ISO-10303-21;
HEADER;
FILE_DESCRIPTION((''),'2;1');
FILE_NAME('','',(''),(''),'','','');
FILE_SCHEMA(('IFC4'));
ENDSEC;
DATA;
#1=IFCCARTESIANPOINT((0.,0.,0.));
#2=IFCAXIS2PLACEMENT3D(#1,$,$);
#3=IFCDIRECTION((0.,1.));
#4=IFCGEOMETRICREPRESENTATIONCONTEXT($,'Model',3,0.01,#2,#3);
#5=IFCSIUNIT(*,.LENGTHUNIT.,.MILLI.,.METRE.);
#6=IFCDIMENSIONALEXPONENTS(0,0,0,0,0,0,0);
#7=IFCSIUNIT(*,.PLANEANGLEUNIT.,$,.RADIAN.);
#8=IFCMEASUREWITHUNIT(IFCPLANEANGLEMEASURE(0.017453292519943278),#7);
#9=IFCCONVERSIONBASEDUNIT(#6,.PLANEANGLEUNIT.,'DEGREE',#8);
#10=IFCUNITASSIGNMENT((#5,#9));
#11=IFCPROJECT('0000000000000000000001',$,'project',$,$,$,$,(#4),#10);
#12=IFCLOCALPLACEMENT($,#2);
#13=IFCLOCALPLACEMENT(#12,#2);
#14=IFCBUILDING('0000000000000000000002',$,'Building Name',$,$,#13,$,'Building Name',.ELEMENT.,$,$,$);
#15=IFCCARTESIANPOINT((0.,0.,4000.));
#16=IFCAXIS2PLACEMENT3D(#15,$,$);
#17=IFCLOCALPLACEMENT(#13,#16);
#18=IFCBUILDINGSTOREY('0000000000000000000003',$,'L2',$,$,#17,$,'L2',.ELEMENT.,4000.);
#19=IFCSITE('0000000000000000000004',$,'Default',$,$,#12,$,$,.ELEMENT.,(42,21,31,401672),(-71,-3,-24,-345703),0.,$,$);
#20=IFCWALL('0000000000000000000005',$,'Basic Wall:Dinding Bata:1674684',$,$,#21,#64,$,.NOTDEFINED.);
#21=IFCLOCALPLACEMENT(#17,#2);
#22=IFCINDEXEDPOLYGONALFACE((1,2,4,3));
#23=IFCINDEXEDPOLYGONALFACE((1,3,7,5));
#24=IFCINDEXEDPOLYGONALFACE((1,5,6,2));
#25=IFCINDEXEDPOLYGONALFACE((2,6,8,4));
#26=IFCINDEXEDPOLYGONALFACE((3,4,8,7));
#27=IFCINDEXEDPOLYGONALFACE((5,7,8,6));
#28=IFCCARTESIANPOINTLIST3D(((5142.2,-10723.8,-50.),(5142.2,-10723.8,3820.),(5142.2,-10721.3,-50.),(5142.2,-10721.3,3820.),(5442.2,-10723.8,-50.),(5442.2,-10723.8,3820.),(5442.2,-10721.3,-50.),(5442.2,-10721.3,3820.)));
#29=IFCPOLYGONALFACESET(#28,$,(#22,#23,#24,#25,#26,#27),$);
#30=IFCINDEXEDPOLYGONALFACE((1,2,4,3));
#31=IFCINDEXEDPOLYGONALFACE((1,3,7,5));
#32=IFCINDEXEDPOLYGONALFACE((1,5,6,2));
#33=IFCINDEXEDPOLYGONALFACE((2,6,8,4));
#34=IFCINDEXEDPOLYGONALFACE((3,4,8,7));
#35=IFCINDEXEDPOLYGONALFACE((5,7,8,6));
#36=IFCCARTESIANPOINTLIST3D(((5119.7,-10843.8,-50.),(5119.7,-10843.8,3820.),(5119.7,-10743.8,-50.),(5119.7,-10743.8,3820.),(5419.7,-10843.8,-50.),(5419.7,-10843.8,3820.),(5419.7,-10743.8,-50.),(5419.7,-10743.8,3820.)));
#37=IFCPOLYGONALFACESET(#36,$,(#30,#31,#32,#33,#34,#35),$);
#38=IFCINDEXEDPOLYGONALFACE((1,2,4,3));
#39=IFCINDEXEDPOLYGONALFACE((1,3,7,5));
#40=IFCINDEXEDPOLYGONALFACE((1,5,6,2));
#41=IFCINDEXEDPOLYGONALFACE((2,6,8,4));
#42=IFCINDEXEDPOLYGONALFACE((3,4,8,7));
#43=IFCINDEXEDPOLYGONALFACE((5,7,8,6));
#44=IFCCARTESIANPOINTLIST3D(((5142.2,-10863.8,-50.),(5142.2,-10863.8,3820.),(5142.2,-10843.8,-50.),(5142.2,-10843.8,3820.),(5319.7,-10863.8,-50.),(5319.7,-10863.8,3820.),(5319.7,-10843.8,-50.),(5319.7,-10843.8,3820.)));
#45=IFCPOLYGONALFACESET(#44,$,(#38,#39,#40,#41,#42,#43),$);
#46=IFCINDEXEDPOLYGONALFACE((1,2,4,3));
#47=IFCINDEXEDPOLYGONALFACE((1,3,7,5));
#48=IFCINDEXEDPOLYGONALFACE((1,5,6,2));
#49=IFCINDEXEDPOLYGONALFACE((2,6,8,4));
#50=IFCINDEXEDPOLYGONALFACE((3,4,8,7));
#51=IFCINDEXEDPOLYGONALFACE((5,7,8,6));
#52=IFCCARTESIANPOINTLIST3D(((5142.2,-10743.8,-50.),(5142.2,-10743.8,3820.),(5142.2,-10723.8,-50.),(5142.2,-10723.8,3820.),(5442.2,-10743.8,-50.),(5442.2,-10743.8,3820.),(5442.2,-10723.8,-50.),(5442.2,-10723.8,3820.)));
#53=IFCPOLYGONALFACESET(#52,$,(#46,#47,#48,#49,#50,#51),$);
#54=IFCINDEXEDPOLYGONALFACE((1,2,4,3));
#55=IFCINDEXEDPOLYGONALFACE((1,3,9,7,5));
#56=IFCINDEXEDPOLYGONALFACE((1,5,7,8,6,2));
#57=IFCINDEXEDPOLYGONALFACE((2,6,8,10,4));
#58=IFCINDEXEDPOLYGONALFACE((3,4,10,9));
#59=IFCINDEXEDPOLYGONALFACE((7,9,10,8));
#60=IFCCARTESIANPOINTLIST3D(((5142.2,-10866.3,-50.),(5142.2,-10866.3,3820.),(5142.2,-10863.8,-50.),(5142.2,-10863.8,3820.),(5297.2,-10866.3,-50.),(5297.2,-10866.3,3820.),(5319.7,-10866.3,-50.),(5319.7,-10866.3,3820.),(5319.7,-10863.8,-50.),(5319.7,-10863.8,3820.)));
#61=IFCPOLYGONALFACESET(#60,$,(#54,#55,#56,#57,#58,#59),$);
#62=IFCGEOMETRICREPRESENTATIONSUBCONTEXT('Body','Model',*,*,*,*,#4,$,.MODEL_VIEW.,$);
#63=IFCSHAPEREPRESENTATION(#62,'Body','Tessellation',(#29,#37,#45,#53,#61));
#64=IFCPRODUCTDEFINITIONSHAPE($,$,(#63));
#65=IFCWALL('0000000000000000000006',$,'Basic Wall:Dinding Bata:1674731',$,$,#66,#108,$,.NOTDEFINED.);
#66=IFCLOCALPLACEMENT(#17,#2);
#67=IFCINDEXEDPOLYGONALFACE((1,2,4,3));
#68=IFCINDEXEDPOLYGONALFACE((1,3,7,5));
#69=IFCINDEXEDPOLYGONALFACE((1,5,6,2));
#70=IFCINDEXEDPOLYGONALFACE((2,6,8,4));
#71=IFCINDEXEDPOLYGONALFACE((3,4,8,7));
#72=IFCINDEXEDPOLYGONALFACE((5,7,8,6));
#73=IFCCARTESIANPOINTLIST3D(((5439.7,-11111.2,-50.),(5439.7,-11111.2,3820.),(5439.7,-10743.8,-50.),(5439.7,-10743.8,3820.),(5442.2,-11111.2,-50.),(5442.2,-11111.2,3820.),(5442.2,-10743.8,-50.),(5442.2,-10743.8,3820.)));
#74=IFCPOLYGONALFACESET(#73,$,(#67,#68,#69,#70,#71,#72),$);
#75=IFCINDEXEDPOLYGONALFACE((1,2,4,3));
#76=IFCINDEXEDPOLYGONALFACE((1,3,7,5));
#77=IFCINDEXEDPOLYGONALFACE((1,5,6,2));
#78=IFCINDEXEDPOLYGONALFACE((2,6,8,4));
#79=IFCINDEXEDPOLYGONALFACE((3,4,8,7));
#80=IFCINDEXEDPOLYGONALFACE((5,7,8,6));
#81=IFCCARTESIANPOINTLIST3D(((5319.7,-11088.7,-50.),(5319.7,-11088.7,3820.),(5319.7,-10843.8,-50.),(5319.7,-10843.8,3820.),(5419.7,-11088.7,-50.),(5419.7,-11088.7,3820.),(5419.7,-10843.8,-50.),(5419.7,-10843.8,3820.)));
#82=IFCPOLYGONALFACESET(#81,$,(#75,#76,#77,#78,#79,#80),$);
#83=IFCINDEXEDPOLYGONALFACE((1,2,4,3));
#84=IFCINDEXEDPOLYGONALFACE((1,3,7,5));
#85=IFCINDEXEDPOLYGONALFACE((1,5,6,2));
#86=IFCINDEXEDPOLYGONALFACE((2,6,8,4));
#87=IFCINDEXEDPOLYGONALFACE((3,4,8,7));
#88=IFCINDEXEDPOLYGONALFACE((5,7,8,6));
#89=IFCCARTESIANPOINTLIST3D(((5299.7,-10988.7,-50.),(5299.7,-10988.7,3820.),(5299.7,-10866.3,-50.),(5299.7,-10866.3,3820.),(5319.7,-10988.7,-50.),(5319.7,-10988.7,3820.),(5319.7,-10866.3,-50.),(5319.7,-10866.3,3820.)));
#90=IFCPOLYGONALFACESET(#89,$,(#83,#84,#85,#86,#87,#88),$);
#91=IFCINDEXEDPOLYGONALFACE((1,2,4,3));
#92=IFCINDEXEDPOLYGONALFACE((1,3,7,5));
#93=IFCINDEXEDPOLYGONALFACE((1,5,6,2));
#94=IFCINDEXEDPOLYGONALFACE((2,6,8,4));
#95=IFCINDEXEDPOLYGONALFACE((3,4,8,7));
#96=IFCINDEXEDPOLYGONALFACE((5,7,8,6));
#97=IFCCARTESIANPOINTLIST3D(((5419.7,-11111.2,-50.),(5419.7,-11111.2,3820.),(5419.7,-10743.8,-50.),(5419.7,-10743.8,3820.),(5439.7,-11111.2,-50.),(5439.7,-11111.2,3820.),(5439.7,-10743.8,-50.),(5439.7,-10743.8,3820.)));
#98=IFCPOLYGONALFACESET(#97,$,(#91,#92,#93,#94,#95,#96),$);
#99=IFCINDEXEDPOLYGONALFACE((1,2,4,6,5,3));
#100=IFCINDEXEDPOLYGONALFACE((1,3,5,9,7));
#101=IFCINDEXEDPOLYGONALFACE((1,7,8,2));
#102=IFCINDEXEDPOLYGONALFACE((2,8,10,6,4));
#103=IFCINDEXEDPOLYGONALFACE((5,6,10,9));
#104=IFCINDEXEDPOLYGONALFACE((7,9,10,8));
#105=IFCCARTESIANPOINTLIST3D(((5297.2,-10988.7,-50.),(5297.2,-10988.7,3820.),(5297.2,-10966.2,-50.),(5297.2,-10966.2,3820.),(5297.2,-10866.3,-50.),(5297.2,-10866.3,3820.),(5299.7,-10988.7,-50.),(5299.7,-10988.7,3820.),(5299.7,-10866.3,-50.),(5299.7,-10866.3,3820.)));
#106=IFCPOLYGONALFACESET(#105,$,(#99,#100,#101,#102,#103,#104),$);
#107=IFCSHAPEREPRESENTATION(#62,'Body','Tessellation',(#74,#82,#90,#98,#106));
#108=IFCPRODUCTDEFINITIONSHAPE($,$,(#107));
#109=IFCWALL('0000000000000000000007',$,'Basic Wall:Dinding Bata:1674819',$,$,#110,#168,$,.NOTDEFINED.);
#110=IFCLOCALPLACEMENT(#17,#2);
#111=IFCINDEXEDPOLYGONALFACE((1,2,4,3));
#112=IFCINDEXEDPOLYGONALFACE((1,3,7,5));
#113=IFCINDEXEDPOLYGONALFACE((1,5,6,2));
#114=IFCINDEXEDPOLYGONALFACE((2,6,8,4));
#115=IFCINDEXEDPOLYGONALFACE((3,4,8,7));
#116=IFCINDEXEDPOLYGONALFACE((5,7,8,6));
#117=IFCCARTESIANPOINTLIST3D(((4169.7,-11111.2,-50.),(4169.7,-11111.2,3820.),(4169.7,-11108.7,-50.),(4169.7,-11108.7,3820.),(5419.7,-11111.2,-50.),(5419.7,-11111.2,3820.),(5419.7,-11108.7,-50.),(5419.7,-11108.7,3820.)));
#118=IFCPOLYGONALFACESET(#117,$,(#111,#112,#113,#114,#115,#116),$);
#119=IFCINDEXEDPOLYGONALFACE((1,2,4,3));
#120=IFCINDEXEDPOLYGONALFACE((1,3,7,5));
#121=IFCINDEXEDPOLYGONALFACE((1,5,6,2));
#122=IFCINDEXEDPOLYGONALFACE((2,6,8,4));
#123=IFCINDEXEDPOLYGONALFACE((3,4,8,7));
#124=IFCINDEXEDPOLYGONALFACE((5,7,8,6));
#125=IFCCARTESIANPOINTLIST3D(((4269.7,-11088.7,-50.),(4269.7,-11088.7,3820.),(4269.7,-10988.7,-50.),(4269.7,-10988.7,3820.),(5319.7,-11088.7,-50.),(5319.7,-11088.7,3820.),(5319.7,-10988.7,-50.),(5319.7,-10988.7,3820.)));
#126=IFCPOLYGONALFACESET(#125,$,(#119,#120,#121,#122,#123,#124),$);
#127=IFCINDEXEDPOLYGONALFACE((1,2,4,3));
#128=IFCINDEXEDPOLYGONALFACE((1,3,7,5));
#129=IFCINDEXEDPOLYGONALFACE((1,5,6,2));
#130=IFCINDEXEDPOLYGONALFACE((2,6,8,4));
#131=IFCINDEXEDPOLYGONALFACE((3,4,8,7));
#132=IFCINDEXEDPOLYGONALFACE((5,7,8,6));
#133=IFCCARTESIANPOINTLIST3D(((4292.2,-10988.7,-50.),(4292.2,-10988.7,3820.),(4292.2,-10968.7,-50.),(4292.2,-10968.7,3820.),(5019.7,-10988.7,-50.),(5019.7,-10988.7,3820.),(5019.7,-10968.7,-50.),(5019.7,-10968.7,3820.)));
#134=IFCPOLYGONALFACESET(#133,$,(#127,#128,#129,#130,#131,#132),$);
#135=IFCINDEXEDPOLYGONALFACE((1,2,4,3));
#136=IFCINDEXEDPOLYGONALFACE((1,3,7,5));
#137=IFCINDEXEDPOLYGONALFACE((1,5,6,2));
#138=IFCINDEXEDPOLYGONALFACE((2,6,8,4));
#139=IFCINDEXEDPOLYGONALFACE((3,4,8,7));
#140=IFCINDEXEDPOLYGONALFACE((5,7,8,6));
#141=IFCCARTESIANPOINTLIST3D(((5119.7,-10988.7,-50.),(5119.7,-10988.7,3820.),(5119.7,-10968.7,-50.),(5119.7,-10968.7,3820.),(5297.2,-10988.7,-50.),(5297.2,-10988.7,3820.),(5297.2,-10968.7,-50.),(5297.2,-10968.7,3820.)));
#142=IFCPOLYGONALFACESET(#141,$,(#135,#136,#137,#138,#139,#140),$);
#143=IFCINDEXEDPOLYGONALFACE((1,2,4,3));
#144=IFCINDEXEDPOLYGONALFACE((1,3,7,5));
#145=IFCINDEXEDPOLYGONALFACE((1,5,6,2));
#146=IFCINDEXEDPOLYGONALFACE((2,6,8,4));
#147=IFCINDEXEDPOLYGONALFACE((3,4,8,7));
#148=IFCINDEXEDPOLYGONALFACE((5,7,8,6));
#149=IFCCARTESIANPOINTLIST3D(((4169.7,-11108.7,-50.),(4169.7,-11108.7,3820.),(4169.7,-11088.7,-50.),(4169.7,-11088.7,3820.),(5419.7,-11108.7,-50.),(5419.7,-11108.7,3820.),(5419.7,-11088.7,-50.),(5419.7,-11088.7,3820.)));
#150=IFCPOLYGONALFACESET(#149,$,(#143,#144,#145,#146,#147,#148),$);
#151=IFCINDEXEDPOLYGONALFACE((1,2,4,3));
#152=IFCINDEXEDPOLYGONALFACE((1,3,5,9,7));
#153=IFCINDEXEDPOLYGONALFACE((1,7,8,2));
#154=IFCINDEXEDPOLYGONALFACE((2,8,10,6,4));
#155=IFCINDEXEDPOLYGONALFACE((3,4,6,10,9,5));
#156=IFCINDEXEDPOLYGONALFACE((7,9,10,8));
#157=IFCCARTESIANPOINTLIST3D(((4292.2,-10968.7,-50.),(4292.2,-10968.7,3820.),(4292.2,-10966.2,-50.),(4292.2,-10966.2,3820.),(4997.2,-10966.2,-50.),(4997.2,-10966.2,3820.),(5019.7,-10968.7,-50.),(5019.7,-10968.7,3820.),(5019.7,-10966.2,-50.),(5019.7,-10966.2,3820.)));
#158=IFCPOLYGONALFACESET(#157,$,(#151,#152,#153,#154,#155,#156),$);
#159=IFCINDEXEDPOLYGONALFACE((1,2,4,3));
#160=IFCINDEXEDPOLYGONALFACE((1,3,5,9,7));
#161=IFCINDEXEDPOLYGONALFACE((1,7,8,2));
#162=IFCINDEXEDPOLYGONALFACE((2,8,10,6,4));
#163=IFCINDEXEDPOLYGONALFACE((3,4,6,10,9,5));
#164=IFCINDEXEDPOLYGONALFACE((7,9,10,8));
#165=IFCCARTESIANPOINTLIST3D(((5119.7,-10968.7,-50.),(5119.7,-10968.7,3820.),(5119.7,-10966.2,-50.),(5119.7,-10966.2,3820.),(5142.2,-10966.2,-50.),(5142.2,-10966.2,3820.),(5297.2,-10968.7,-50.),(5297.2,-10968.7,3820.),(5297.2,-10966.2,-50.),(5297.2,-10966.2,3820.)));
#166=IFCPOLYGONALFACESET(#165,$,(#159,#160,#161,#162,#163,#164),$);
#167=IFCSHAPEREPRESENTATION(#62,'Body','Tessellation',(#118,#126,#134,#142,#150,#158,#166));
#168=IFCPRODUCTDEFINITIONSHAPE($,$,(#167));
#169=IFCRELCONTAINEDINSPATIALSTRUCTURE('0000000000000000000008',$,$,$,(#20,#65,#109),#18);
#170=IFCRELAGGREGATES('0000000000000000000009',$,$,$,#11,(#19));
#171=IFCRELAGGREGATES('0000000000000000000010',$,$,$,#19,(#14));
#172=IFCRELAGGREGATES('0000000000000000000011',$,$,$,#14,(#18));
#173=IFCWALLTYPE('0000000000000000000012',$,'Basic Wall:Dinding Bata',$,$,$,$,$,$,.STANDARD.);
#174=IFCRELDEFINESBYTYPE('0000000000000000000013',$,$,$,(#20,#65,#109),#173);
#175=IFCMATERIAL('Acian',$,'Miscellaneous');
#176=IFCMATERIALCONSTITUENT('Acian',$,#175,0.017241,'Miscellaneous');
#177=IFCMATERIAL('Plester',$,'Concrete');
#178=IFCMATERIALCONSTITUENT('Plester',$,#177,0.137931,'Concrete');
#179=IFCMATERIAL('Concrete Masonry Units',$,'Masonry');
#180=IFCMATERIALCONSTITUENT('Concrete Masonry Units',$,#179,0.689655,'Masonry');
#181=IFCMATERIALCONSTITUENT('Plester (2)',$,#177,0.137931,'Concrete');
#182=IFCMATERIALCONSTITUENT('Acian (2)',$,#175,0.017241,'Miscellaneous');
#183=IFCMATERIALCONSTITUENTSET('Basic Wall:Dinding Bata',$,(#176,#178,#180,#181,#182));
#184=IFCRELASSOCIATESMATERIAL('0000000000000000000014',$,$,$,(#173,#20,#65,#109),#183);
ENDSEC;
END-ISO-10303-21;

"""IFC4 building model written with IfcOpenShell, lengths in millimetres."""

from ifc_helpers import new_model, entity, si_unit, converted_unit, direction, frame, origin, place, context, subcontext, project, spatial, indexed_curve, outline, extrude, material, constituent, constituent_set, type_object, element, save


model = new_model("IFC4")

# Units and contexts
model_context = context("Model", 3, precision=0.01, world=origin(), true_north=direction((0.0, 1.0)))
body_context = subcontext(model_context, "Body", "Model", "MODEL_VIEW")
ifc_project = project(units=[si_unit("LENGTHUNIT", "METRE", prefix="MILLI"), converted_unit("PLANEANGLEUNIT", "DEGREE", entity("IfcPlaneAngleMeasure", 0.017453292519943278), si_unit("PLANEANGLEUNIT", "RADIAN"), dimensions=[0, 0, 0, 0, 0, 0, 0])], contexts=[model_context])

# Site, building, storey
site_placement = place(None, origin())
site = spatial("IfcSite", under=ifc_project, at=site_placement, Name="Default", CompositionType="ELEMENT", RefLatitude=(42, 21, 31, 401672), RefLongitude=(-71, -3, -24, -345703), RefElevation=0.0)
building_placement = place(site_placement, origin())
building = spatial("IfcBuilding", under=site, at=building_placement, Name="Building Name", LongName="Building Name", CompositionType="ELEMENT")
storey_placement = place(building_placement, frame((0.0, 0.0, 4000.0)))
storey = spatial("IfcBuildingStorey", under=building, at=storey_placement, Name="L2", LongName="L2", CompositionType="ELEMENT", Elevation=4000.0)

# Walls
ifc_material_1 = material(Name="Acian", Category="Miscellaneous")
ifc_constituent_1 = constituent(ifc_material_1, Name="Acian", Category="Miscellaneous", fraction=0.017241)
ifc_material_2 = material(Name="Plester", Category="Concrete")
ifc_constituent_2 = constituent(ifc_material_2, Name="Plester", Category="Concrete", fraction=0.137931)
ifc_material_3 = material(Name="Concrete Masonry Units", Category="Masonry")
ifc_constituent_3 = constituent(ifc_material_3, Name="Concrete Masonry Units", Category="Masonry", fraction=0.689655)
ifc_constituent_4 = constituent(ifc_material_2, Name="Plester (2)", Category="Concrete", fraction=0.137931)
ifc_constituent_5 = constituent(ifc_material_1, Name="Acian (2)", Category="Miscellaneous", fraction=0.017241)
ifc_constituent_set = constituent_set(constituents=[ifc_constituent_1, ifc_constituent_2, ifc_constituent_3, ifc_constituent_4, ifc_constituent_5], Name="Basic Wall:Dinding Bata")
wall_type = type_object("IfcWallType", Name="Basic Wall:Dinding Bata", PredefinedType="STANDARD", material=ifc_constituent_set)
wall_1_placement = place(storey_placement, frame((5142.2, -10793.8, -50.0)))
element("IfcWall", 1, at=wall_1_placement, inside=storey, type_object=wall_type, material=ifc_constituent_set, Name="Basic Wall:Dinding Bata:1674684", PredefinedType="NOTDEFINED", context=body_context, shape_type="SweptSolid", body=[
    extrude(outline(indexed_curve([(-1.2, -150.0), (1.3, -150.0), (1.3, 150.0), (-1.2, 150.0), (-1.2, -150.0)], self_intersect=False)), frame((150.0, 71.3, 0.0), z_axis=(0.0, 0.0, 1.0), x_axis=(0.0, -1.0, 0.0)), (0.0, 0.0, 1.0), 3870.0),
    extrude(outline(indexed_curve([(-150.0, -50.0), (150.0, -50.0), (150.0, 50.0), (-150.0, 50.0), (-150.0, -50.0)], self_intersect=False)), frame((127.5, 0.0, 0.0)), (0.0, 0.0, 1.0), 3870.0),
    extrude(outline(indexed_curve([(-88.8, -10.0), (88.8, -10.0), (88.8, 10.0), (-88.8, 10.0), (-88.8, -10.0)], self_intersect=False)), frame((88.8, -60.0, 0.0)), (0.0, 0.0, 1.0), 3870.0),
    extrude(outline(indexed_curve([(-150.0, -10.0), (150.0, -10.0), (150.0, 10.0), (-150.0, 10.0), (-150.0, -10.0)], self_intersect=False)), frame((150.0, 60.0, 0.0)), (0.0, 0.0, 1.0), 3870.0),
    extrude(outline(indexed_curve([(53.0, -1.0), (75.5, -1.0), (75.5, 1.5), (-102.0, 1.5), (-102.0, -1.0), (53.0, -1.0)], self_intersect=False)), frame((102.0, -71.5, 0.0)), (0.0, 0.0, 1.0), 3870.0),
])
wall_2_placement = place(storey_placement, frame((5369.7, -10866.3, -50.0), z_axis=(0.0, 0.0, 1.0), x_axis=(0.0, -1.0, 0.0)))
element("IfcWall", 2, at=wall_2_placement, inside=storey, type_object=wall_type, material=ifc_constituent_set, Name="Basic Wall:Dinding Bata:1674731", PredefinedType="NOTDEFINED", context=body_context, shape_type="SweptSolid", body=[
    extrude(outline(indexed_curve([(-1.2, -183.7), (1.2, -183.7), (1.2, 183.7), (-1.2, 183.7), (-1.2, -183.7)], self_intersect=False)), frame((61.2, 71.3, 0.0), z_axis=(0.0, 0.0, 1.0), x_axis=(0.0, -1.0, 0.0)), (0.0, 0.0, 1.0), 3870.0),
    extrude(outline(indexed_curve([(-122.4, -50.0), (122.4, -50.0), (122.4, 50.0), (-122.4, 50.0), (-122.4, -50.0)], self_intersect=False)), frame((99.9, 0.0, 0.0)), (0.0, 0.0, 1.0), 3870.0),
    extrude(outline(indexed_curve([(-61.2, -10.0), (61.2, -10.0), (61.2, 10.0), (-61.2, 10.0), (-61.2, -10.0)], self_intersect=False)), frame((61.2, -60.0, 0.0)), (0.0, 0.0, 1.0), 3870.0),
    extrude(outline(indexed_curve([(-183.7, -10.0), (183.7, -10.0), (183.7, 10.0), (-183.7, 10.0), (-183.7, -10.0)], self_intersect=False)), frame((61.2, 60.0, 0.0)), (0.0, 0.0, 1.0), 3870.0),
    extrude(outline(indexed_curve([(31.0, -1.0), (53.5, -1.0), (53.5, 1.5), (-68.9, 1.5), (-68.9, -1.0), (31.0, -1.0)], self_intersect=False)), frame((68.9, -71.5, 0.0)), (0.0, 0.0, 1.0), 3870.0),
])
wall_3_placement = place(storey_placement, frame((5297.2, -11038.7, -50.0), z_axis=(0.0, 0.0, 1.0), x_axis=(-1.0, 0.0, 0.0)))
element("IfcWall", 3, at=wall_3_placement, inside=storey, type_object=wall_type, material=ifc_constituent_set, Name="Basic Wall:Dinding Bata:1674819", PredefinedType="NOTDEFINED", context=body_context, shape_type="SweptSolid", body=[
    extrude(outline(indexed_curve([(-1.3, -625.0), (1.2, -625.0), (1.3, 625.0), (-1.2, 625.0), (-1.3, -625.0)], self_intersect=False)), frame((502.5, 71.3, 0.0), z_axis=(0.0, 0.0, 1.0), x_axis=(0.0, -1.0, 0.0)), (0.0, 0.0, 1.0), 3870.0),
    extrude(outline(indexed_curve([(-525.0, -50.0), (525.0, -50.0), (525.0, 50.0), (-525.0, 50.0), (-525.0, -50.0)], self_intersect=False)), frame((502.5, 0.0, 0.0)), (0.0, 0.0, 1.0), 3870.0),
    extrude(outline(indexed_curve([(-363.7, -10.0), (363.7, -10.0), (363.7, 10.0), (-363.7, 10.0), (-363.7, -10.0)], self_intersect=False)), frame((641.2, -60.0, 0.0), z_axis=(0.0, 0.0, 1.0), x_axis=(-1.0, 0.0, 0.0)), (0.0, 0.0, 1.0), 3870.0),
    extrude(outline(indexed_curve([(-88.8, -10.0), (88.8, -10.0), (88.8, 10.0), (-88.8, 10.0), (-88.8, -10.0)], self_intersect=False)), frame((88.8, -60.0, 0.0)), (0.0, 0.0, 1.0), 3870.0),
    extrude(outline(indexed_curve([(-625.0, -10.0), (625.0, -10.0), (625.0, 10.0), (-625.0, 10.0), (-625.0, -10.0)], self_intersect=False)), frame((502.5, 60.0, 0.0)), (0.0, 0.0, 1.0), 3870.0),
    extrude(outline(indexed_curve([(-1.0, -432.0), (1.5, -432.0), (1.5, 295.5), (-1.0, 295.5), (-1.0, 273.0), (-1.0, -432.0)], self_intersect=False)), frame((573.0, -71.5, 0.0), z_axis=(0.0, 0.0, 1.0), x_axis=(0.0, 1.0, 0.0)), (0.0, 0.0, 1.0), 3870.0),
    extrude(outline(indexed_curve([(53.0, -1.0), (75.5, -1.0), (75.5, 1.5), (-102.0, 1.5), (-102.0, -1.0), (53.0, -1.0)], self_intersect=False)), frame((102.0, -71.5, 0.0)), (0.0, 0.0, 1.0), 3870.0),
])

save(model, "model.ifc")
